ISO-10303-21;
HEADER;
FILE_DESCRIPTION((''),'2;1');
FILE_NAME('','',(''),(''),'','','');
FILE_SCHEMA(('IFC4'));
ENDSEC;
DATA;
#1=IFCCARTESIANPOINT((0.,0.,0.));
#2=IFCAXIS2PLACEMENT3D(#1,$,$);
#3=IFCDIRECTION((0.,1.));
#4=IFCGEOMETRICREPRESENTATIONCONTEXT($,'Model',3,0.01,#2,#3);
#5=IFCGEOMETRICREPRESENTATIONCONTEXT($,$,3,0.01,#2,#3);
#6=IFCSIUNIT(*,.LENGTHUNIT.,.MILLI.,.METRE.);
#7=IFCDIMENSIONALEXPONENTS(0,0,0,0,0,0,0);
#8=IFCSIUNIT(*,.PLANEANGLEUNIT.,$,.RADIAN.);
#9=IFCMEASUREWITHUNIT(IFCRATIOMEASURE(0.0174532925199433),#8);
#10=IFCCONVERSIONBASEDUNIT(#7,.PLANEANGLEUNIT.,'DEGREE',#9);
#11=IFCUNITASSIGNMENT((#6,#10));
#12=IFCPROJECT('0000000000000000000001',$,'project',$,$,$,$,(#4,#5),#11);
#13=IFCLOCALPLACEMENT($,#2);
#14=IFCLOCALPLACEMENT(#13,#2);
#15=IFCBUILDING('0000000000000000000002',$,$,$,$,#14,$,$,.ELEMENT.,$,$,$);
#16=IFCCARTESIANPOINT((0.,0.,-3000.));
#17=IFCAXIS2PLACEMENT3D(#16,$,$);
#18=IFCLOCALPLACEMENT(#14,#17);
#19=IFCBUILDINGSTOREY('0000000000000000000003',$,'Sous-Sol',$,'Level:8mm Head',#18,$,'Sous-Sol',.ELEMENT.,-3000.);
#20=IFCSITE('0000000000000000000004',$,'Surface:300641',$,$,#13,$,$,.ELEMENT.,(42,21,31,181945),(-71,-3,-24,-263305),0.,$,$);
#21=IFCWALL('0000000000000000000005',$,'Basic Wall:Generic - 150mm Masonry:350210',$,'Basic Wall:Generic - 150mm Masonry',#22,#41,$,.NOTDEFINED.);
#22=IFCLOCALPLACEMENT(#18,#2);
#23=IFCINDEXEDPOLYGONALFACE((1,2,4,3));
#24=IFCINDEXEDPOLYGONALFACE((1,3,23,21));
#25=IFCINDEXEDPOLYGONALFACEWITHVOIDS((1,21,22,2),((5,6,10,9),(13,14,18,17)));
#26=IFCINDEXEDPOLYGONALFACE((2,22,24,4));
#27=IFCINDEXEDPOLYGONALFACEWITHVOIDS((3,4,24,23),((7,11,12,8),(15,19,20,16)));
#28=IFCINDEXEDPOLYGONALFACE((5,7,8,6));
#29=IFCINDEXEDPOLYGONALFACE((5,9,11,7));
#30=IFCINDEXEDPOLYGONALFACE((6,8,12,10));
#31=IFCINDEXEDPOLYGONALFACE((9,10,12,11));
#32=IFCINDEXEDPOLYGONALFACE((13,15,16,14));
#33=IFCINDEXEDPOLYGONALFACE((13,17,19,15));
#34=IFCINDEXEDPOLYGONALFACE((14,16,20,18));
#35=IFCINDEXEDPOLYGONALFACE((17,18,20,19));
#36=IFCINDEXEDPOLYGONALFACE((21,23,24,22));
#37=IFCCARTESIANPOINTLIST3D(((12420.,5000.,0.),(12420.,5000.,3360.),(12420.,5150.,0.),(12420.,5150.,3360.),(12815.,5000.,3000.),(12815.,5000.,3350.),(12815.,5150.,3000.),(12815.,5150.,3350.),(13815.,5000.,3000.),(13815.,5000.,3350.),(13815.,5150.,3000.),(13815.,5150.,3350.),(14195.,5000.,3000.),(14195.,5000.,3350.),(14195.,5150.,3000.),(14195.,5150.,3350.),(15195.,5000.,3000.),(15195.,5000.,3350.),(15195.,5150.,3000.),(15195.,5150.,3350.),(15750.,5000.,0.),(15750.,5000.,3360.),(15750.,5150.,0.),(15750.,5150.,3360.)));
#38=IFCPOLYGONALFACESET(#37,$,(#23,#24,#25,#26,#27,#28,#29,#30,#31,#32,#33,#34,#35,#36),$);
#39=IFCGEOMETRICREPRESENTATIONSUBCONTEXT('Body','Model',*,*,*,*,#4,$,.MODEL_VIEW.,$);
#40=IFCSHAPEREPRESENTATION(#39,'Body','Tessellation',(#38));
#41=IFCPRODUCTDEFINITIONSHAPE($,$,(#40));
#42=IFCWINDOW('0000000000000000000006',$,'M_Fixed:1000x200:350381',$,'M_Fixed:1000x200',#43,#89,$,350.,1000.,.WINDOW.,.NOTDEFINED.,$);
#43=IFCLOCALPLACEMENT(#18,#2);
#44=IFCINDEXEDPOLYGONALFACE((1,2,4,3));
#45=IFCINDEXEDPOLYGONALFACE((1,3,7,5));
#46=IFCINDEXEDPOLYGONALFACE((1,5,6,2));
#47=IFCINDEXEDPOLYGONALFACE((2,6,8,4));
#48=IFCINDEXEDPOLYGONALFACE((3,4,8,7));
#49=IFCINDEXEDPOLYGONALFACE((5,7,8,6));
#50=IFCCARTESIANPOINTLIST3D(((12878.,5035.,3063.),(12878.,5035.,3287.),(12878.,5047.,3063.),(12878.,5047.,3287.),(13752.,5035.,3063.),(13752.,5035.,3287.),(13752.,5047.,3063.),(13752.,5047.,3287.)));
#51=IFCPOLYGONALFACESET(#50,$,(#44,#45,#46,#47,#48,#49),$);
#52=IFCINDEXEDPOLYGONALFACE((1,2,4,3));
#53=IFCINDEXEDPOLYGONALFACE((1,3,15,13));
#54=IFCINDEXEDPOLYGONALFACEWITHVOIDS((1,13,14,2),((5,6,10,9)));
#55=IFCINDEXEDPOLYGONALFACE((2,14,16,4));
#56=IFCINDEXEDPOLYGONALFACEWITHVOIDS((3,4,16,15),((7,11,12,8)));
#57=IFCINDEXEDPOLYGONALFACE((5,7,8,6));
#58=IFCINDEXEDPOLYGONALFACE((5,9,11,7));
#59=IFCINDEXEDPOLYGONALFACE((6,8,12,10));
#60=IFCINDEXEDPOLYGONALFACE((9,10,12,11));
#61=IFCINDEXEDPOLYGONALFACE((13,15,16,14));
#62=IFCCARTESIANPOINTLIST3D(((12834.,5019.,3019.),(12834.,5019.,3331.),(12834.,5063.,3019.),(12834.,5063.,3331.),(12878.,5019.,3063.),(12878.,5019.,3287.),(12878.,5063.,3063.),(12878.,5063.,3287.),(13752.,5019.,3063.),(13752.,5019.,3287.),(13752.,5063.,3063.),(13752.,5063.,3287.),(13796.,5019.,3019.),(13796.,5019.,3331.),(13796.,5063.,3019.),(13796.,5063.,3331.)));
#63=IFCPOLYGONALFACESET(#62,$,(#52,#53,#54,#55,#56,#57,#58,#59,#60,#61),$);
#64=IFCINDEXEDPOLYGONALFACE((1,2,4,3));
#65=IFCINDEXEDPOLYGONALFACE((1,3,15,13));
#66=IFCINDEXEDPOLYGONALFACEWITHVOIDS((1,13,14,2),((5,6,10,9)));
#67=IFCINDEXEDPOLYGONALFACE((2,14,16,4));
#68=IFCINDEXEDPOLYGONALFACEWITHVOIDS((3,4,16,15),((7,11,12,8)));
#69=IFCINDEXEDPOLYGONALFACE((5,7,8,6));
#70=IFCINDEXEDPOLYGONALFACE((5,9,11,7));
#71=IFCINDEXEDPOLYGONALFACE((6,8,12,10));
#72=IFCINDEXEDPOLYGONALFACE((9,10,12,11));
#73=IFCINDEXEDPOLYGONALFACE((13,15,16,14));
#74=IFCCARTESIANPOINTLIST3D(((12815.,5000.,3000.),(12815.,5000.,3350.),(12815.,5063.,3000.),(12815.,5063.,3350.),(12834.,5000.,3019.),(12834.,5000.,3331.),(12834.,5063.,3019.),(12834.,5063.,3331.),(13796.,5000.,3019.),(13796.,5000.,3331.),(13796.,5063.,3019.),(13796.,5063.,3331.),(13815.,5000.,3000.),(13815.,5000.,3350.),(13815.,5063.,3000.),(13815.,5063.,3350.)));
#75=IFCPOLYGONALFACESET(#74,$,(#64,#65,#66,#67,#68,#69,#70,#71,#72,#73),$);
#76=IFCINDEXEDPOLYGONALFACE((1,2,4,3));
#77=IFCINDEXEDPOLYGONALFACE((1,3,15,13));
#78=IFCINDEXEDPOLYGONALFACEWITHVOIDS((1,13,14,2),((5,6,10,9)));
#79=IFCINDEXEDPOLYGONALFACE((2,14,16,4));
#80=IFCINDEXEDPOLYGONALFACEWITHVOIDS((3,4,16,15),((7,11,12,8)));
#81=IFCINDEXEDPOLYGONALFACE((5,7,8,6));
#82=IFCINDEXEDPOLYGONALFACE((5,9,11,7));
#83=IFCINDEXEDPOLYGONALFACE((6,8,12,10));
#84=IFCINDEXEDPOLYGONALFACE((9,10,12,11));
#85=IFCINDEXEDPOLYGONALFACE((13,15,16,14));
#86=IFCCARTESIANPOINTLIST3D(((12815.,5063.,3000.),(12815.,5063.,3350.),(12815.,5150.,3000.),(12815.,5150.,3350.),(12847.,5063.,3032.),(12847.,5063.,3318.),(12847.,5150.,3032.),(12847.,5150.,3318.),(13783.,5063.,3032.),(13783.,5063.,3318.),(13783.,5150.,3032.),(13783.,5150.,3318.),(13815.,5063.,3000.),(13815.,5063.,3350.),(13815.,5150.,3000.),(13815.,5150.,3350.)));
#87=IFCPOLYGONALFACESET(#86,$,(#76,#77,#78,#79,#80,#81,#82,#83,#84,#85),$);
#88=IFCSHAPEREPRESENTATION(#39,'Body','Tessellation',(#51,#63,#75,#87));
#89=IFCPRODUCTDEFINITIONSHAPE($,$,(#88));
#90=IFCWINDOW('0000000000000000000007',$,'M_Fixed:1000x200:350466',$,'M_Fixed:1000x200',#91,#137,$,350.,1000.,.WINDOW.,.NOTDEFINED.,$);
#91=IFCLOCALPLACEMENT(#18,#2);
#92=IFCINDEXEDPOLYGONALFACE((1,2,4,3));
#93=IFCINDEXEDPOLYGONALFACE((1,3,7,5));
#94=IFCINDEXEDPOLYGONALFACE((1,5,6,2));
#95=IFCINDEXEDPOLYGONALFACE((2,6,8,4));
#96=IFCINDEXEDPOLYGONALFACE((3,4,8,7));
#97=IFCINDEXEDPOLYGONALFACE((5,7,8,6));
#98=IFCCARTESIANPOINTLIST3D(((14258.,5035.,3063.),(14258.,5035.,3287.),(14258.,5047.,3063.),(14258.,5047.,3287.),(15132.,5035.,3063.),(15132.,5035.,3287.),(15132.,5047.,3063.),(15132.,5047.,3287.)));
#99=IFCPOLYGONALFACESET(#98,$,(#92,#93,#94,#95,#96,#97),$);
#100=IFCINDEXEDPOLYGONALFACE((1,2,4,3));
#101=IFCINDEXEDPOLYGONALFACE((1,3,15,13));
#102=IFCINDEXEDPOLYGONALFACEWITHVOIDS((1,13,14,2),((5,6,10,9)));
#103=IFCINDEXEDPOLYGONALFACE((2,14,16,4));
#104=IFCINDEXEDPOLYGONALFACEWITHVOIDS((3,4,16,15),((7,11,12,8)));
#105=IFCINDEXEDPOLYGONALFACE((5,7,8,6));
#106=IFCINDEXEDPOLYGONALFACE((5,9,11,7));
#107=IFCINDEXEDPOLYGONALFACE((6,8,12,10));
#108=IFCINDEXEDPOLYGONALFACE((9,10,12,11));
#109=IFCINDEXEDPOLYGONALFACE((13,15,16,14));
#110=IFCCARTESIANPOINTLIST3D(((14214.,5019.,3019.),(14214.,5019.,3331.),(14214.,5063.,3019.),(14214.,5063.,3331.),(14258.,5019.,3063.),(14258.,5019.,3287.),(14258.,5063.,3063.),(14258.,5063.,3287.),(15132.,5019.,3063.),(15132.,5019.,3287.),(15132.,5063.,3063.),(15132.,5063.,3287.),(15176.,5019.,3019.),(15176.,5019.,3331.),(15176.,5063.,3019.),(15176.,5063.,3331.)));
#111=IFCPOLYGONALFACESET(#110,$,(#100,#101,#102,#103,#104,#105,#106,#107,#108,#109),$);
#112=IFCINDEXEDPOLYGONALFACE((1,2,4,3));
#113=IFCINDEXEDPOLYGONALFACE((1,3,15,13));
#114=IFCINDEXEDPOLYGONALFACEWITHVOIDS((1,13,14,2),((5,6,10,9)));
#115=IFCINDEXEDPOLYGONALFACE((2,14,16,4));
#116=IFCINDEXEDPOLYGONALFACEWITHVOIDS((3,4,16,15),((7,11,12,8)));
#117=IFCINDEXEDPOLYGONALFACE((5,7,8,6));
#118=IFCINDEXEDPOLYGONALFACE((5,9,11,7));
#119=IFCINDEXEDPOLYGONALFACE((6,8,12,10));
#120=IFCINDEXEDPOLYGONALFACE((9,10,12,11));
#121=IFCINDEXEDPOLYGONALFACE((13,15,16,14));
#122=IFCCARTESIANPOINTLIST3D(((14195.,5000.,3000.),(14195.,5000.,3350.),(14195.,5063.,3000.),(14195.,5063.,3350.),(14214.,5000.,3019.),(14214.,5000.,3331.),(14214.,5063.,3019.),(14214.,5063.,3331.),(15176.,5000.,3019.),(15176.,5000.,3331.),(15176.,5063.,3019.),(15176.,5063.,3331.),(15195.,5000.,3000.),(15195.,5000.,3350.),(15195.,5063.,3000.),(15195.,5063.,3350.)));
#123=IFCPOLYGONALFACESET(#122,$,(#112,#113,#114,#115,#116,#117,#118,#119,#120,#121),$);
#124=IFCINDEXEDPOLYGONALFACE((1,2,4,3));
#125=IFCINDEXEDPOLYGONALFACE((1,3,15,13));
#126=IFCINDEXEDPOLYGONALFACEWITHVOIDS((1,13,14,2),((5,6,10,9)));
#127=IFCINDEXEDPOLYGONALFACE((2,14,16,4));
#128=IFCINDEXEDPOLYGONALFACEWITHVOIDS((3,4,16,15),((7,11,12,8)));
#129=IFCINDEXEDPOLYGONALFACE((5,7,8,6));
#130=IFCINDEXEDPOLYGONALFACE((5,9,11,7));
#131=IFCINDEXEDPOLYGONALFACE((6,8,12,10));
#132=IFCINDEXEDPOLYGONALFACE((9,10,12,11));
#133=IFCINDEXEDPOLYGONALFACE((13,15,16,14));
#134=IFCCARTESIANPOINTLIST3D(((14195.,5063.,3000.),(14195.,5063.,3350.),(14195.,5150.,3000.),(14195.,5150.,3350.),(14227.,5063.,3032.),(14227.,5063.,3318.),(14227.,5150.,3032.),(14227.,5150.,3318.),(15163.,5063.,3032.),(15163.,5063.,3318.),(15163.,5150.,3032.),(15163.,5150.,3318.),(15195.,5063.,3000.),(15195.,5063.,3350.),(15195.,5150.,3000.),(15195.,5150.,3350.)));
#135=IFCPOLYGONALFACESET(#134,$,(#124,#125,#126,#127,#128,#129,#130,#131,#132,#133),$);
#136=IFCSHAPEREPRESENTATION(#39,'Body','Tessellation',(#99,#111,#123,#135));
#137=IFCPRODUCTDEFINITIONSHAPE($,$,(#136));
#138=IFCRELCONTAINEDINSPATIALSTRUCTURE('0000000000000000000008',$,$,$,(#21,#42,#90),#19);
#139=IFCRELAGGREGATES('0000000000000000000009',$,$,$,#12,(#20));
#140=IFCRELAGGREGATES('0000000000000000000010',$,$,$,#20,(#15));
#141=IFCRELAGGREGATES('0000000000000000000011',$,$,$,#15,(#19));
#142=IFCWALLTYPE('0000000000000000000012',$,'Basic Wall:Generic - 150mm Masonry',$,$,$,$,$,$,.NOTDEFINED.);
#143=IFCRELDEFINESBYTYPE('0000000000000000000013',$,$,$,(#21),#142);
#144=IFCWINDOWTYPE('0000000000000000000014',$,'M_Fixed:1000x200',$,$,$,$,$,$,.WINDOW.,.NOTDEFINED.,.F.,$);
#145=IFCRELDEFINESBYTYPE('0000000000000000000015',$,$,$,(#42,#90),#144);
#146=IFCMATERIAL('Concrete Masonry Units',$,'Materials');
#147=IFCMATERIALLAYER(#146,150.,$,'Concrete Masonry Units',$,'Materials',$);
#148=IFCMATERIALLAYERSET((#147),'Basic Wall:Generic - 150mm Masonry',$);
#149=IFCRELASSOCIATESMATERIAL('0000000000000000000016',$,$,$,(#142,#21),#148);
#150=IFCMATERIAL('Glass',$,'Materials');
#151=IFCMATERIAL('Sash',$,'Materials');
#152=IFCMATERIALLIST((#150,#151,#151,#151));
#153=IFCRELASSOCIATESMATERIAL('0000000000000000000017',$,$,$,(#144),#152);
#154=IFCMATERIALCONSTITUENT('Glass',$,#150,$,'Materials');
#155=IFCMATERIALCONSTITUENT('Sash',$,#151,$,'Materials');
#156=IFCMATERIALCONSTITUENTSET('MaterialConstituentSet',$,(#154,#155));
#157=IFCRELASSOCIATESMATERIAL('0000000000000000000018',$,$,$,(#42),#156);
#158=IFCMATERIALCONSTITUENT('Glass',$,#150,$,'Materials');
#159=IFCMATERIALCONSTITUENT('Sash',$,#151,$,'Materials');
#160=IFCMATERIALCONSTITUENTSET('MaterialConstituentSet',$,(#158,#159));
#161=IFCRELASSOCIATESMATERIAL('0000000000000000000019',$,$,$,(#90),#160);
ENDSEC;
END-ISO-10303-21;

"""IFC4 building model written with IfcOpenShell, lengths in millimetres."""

from ifc_helpers import new_model, entity, si_unit, converted_unit, direction, frame, frame_2d, origin, origin_2d_with_axis, place, context, subcontext, project, spatial, polyline, rectangle, outline, extrude, clip, bounded_halfspace, source, transform, mapped, material, material_list, layer, layer_set, layer_usage, constituent, constituent_set, type_object, type_shapes, element, fill, save


model = new_model("IFC4")

# Units and contexts
model_context = context("Model", 3, precision=0.01, world=origin(), true_north=direction((0.0, 1.0)))
context_of_model = context(None, 3, precision=0.01, world=origin(), true_north=direction((0.0, 1.0)))
body_context = subcontext(model_context, "Body", "Model", "MODEL_VIEW")
ifc_project = project(units=[si_unit("LENGTHUNIT", "METRE", prefix="MILLI"), converted_unit("PLANEANGLEUNIT", "DEGREE", entity("IfcRatioMeasure", 0.0174532925199433), si_unit("PLANEANGLEUNIT", "RADIAN"), dimensions=[0, 0, 0, 0, 0, 0, 0])], contexts=[model_context, context_of_model])

# Site, building, storey
site_placement = place(None, origin())
site = spatial("IfcSite", under=ifc_project, at=site_placement, Name="Surface:300641", CompositionType="ELEMENT", RefLatitude=(42, 21, 31, 181945), RefLongitude=(-71, -3, -24, -263305), RefElevation=0.0)
building_placement = place(site_placement, origin())
building = spatial("IfcBuilding", under=site, at=building_placement, CompositionType="ELEMENT")
storey_placement = place(building_placement, frame((0.0, 0.0, -3000.0)))
storey = spatial("IfcBuildingStorey", under=building, at=storey_placement, Name="Sous-Sol", ObjectType="Level:8mm Head", LongName="Sous-Sol", CompositionType="ELEMENT", Elevation=-3000.0)

# Shared definitions
ifc_material_1 = material(Name="Glass", Category="Materials")
ifc_material_2 = material(Name="Sash", Category="Materials")

# Wall, openings, windows
ifc_material_3 = material(Name="Concrete Masonry Units", Category="Materials")
ifc_layer_1 = layer(ifc_material_3, 150.0, Name="Concrete Masonry Units", Category="Materials")
ifc_layer_set_1 = layer_set([ifc_layer_1], Name="Basic Wall:Generic - 150mm Masonry")
ifc_layer_usage_1 = layer_usage(ifc_layer_set_1, "AXIS2", "NEGATIVE", 75.0)
wall_type_1 = type_object("IfcWallType", Name="Basic Wall:Generic - 150mm Masonry", PredefinedType="NOTDEFINED", material=ifc_layer_set_1)
wall_1_placement = place(storey_placement, frame((12420.0, 5075.0, 0.0)))
wall_1 = element("IfcWall", 1, at=wall_1_placement, inside=storey, type_object=wall_type_1, material=ifc_layer_usage_1, Name="Basic Wall:Generic - 150mm Masonry:350210", ObjectType="Basic Wall:Generic - 150mm Masonry", PredefinedType="NOTDEFINED", context=body_context, shape_type="Clipping", body=[
    clip(extrude(rectangle(XDim=3330.0, YDim=150.0, at=frame_2d((1665.0, 0.0), x_axis=(-1.0, 0.0))), origin(), (0.0, 0.0, 1.0), 3360.0), bounded_halfspace(frame((0.0, -75.0, 3360.0), z_axis=(0.0, 0.0, -1.0), x_axis=(0.0, -1.0, 0.0)), True, frame((0.0, -75.0, 3360.0)), polyline([(0.0, 0.0), (3330.0, 0.0), (3330.0, 150.0), (0.0, 150.0), (0.0, 0.0)]))),
])
opening_1_placement = place(wall_1_placement, frame((2775.0, 75.0, 3000.0)))
opening_1 = element("IfcOpeningElement", 2, at=opening_1_placement, cuts=wall_1, ObjectType="Opening", PredefinedType="OPENING", context=body_context, shape_type="SweptSolid", body=[
    extrude(rectangle(XDim=350.0, YDim=1000.0, at=frame_2d((175.0, 500.0), x_axis=(1.0, 0.0))), frame((0.0, 0.0, 0.0), z_axis=(0.0, -1.0, 0.0), x_axis=(0.0, 0.0, 1.0)), (0.0, 0.0, 1.0), 150.0),
])
opening_2_placement = place(wall_1_placement, frame((1395.0, 75.0, 3000.0)))
opening_2 = element("IfcOpeningElement", 3, at=opening_2_placement, cuts=wall_1, ObjectType="Opening", PredefinedType="OPENING", context=body_context, shape_type="SweptSolid", body=[
    extrude(rectangle(XDim=350.0, YDim=1000.0, at=frame_2d((175.0, 500.0), x_axis=(1.0, 0.0))), frame((0.0, 0.0, 0.0), z_axis=(0.0, -1.0, 0.0), x_axis=(0.0, 0.0, 1.0)), (0.0, 0.0, 1.0), 150.0),
])
ifc_constituent_1 = constituent(ifc_material_1, Name="Glass", Category="Materials")
ifc_constituent_2 = constituent(ifc_material_2, Name="Sash", Category="Materials")
ifc_constituent_set_1 = constituent_set(constituents=[ifc_constituent_1, ifc_constituent_2], Name="MaterialConstituentSet")
ifc_material_list_1 = material_list([ifc_material_1, ifc_material_2, ifc_material_2, ifc_material_2])
window_type_1 = type_object("IfcWindowType", Name="M_Fixed:1000x200", ParameterTakesPrecedence=False, PartitioningType="NOTDEFINED", PredefinedType="WINDOW", material=ifc_material_list_1)
shared_shape_1 = source(origin(), body_context, "Body", "SweptSolid", [
    extrude(rectangle(XDim=12.0, YDim=874.0, at=origin_2d_with_axis()), frame((500.0, 109.0, 63.0), z_axis=(0.0, 0.0, 1.0), x_axis=(0.0, -1.0, 0.0)), (0.0, 0.0, 1.0), 224.0),
    extrude(outline(polyline([(-481.0, -156.0), (481.0, -156.0), (481.0, 156.0), (-481.0, 156.0), (-481.0, -156.0)]), holes=[polyline([(-437.0, -112.0), (-437.0, 112.0), (437.0, 112.0), (437.0, -112.0), (-437.0, -112.0)])]), frame((500.0, 87.0, 175.0), z_axis=(0.0, 1.0, 0.0), x_axis=(1.0, 0.0, 0.0)), (0.0, 0.0, 1.0), 44.0),
    extrude(outline(polyline([(-500.0, -175.0), (500.0, -175.0), (500.0, 175.0), (-500.0, 175.0), (-500.0, -175.0)]), holes=[polyline([(-481.0, -156.0), (-481.0, 156.0), (481.0, 156.0), (481.0, -156.0), (-481.0, -156.0)])]), frame((500.0, 87.0, 175.0), z_axis=(0.0, 1.0, 0.0), x_axis=(1.0, 0.0, 0.0)), (0.0, 0.0, 1.0), 63.0),
    extrude(outline(polyline([(-500.0, -175.0), (500.0, -175.0), (500.0, 175.0), (-500.0, 175.0), (-500.0, -175.0)]), holes=[polyline([(-468.0, -143.0), (-468.0, 143.0), (468.0, 143.0), (468.0, -143.0), (-468.0, -143.0)])]), frame((500.0, 0.0, 175.0), z_axis=(0.0, 1.0, 0.0), x_axis=(1.0, 0.0, 0.0)), (0.0, 0.0, 1.0), 87.0),
])
type_shapes(window_type_1, [shared_shape_1])
window_1_placement = place(opening_2_placement, frame((0.0, 0.0, 0.0), z_axis=(0.0, 0.0, 1.0), x_axis=(-1.0, 0.0, 0.0)))
window_1 = element("IfcWindow", 4, at=window_1_placement, inside=storey, type_object=window_type_1, material=ifc_constituent_set_1, Name="M_Fixed:1000x200:350381", ObjectType="M_Fixed:1000x200", OverallHeight=350.0, OverallWidth=1000.0, PartitioningType="NOTDEFINED", PredefinedType="WINDOW", context=body_context, shape_type="MappedRepresentation", body=[
    mapped(shared_shape_1, transform((0.0, 0.0, 0.0), scale=1.0)),
])
fill(opening_2, window_1)
ifc_constituent_3 = constituent(ifc_material_1, Name="Glass", Category="Materials")
ifc_constituent_4 = constituent(ifc_material_2, Name="Sash", Category="Materials")
ifc_constituent_set_2 = constituent_set(constituents=[ifc_constituent_3, ifc_constituent_4], Name="MaterialConstituentSet")
window_2_placement = place(opening_1_placement, frame((0.0, 0.0, 0.0), z_axis=(0.0, 0.0, 1.0), x_axis=(-1.0, 0.0, 0.0)))
window_2 = element("IfcWindow", 5, at=window_2_placement, inside=storey, type_object=window_type_1, material=ifc_constituent_set_2, Name="M_Fixed:1000x200:350466", ObjectType="M_Fixed:1000x200", OverallHeight=350.0, OverallWidth=1000.0, PartitioningType="NOTDEFINED", PredefinedType="WINDOW", context=body_context, shape_type="MappedRepresentation", body=[
    mapped(shared_shape_1, transform((0.0, 0.0, 0.0), scale=1.0)),
])
fill(opening_1, window_2)

save(model, "model.ifc")
